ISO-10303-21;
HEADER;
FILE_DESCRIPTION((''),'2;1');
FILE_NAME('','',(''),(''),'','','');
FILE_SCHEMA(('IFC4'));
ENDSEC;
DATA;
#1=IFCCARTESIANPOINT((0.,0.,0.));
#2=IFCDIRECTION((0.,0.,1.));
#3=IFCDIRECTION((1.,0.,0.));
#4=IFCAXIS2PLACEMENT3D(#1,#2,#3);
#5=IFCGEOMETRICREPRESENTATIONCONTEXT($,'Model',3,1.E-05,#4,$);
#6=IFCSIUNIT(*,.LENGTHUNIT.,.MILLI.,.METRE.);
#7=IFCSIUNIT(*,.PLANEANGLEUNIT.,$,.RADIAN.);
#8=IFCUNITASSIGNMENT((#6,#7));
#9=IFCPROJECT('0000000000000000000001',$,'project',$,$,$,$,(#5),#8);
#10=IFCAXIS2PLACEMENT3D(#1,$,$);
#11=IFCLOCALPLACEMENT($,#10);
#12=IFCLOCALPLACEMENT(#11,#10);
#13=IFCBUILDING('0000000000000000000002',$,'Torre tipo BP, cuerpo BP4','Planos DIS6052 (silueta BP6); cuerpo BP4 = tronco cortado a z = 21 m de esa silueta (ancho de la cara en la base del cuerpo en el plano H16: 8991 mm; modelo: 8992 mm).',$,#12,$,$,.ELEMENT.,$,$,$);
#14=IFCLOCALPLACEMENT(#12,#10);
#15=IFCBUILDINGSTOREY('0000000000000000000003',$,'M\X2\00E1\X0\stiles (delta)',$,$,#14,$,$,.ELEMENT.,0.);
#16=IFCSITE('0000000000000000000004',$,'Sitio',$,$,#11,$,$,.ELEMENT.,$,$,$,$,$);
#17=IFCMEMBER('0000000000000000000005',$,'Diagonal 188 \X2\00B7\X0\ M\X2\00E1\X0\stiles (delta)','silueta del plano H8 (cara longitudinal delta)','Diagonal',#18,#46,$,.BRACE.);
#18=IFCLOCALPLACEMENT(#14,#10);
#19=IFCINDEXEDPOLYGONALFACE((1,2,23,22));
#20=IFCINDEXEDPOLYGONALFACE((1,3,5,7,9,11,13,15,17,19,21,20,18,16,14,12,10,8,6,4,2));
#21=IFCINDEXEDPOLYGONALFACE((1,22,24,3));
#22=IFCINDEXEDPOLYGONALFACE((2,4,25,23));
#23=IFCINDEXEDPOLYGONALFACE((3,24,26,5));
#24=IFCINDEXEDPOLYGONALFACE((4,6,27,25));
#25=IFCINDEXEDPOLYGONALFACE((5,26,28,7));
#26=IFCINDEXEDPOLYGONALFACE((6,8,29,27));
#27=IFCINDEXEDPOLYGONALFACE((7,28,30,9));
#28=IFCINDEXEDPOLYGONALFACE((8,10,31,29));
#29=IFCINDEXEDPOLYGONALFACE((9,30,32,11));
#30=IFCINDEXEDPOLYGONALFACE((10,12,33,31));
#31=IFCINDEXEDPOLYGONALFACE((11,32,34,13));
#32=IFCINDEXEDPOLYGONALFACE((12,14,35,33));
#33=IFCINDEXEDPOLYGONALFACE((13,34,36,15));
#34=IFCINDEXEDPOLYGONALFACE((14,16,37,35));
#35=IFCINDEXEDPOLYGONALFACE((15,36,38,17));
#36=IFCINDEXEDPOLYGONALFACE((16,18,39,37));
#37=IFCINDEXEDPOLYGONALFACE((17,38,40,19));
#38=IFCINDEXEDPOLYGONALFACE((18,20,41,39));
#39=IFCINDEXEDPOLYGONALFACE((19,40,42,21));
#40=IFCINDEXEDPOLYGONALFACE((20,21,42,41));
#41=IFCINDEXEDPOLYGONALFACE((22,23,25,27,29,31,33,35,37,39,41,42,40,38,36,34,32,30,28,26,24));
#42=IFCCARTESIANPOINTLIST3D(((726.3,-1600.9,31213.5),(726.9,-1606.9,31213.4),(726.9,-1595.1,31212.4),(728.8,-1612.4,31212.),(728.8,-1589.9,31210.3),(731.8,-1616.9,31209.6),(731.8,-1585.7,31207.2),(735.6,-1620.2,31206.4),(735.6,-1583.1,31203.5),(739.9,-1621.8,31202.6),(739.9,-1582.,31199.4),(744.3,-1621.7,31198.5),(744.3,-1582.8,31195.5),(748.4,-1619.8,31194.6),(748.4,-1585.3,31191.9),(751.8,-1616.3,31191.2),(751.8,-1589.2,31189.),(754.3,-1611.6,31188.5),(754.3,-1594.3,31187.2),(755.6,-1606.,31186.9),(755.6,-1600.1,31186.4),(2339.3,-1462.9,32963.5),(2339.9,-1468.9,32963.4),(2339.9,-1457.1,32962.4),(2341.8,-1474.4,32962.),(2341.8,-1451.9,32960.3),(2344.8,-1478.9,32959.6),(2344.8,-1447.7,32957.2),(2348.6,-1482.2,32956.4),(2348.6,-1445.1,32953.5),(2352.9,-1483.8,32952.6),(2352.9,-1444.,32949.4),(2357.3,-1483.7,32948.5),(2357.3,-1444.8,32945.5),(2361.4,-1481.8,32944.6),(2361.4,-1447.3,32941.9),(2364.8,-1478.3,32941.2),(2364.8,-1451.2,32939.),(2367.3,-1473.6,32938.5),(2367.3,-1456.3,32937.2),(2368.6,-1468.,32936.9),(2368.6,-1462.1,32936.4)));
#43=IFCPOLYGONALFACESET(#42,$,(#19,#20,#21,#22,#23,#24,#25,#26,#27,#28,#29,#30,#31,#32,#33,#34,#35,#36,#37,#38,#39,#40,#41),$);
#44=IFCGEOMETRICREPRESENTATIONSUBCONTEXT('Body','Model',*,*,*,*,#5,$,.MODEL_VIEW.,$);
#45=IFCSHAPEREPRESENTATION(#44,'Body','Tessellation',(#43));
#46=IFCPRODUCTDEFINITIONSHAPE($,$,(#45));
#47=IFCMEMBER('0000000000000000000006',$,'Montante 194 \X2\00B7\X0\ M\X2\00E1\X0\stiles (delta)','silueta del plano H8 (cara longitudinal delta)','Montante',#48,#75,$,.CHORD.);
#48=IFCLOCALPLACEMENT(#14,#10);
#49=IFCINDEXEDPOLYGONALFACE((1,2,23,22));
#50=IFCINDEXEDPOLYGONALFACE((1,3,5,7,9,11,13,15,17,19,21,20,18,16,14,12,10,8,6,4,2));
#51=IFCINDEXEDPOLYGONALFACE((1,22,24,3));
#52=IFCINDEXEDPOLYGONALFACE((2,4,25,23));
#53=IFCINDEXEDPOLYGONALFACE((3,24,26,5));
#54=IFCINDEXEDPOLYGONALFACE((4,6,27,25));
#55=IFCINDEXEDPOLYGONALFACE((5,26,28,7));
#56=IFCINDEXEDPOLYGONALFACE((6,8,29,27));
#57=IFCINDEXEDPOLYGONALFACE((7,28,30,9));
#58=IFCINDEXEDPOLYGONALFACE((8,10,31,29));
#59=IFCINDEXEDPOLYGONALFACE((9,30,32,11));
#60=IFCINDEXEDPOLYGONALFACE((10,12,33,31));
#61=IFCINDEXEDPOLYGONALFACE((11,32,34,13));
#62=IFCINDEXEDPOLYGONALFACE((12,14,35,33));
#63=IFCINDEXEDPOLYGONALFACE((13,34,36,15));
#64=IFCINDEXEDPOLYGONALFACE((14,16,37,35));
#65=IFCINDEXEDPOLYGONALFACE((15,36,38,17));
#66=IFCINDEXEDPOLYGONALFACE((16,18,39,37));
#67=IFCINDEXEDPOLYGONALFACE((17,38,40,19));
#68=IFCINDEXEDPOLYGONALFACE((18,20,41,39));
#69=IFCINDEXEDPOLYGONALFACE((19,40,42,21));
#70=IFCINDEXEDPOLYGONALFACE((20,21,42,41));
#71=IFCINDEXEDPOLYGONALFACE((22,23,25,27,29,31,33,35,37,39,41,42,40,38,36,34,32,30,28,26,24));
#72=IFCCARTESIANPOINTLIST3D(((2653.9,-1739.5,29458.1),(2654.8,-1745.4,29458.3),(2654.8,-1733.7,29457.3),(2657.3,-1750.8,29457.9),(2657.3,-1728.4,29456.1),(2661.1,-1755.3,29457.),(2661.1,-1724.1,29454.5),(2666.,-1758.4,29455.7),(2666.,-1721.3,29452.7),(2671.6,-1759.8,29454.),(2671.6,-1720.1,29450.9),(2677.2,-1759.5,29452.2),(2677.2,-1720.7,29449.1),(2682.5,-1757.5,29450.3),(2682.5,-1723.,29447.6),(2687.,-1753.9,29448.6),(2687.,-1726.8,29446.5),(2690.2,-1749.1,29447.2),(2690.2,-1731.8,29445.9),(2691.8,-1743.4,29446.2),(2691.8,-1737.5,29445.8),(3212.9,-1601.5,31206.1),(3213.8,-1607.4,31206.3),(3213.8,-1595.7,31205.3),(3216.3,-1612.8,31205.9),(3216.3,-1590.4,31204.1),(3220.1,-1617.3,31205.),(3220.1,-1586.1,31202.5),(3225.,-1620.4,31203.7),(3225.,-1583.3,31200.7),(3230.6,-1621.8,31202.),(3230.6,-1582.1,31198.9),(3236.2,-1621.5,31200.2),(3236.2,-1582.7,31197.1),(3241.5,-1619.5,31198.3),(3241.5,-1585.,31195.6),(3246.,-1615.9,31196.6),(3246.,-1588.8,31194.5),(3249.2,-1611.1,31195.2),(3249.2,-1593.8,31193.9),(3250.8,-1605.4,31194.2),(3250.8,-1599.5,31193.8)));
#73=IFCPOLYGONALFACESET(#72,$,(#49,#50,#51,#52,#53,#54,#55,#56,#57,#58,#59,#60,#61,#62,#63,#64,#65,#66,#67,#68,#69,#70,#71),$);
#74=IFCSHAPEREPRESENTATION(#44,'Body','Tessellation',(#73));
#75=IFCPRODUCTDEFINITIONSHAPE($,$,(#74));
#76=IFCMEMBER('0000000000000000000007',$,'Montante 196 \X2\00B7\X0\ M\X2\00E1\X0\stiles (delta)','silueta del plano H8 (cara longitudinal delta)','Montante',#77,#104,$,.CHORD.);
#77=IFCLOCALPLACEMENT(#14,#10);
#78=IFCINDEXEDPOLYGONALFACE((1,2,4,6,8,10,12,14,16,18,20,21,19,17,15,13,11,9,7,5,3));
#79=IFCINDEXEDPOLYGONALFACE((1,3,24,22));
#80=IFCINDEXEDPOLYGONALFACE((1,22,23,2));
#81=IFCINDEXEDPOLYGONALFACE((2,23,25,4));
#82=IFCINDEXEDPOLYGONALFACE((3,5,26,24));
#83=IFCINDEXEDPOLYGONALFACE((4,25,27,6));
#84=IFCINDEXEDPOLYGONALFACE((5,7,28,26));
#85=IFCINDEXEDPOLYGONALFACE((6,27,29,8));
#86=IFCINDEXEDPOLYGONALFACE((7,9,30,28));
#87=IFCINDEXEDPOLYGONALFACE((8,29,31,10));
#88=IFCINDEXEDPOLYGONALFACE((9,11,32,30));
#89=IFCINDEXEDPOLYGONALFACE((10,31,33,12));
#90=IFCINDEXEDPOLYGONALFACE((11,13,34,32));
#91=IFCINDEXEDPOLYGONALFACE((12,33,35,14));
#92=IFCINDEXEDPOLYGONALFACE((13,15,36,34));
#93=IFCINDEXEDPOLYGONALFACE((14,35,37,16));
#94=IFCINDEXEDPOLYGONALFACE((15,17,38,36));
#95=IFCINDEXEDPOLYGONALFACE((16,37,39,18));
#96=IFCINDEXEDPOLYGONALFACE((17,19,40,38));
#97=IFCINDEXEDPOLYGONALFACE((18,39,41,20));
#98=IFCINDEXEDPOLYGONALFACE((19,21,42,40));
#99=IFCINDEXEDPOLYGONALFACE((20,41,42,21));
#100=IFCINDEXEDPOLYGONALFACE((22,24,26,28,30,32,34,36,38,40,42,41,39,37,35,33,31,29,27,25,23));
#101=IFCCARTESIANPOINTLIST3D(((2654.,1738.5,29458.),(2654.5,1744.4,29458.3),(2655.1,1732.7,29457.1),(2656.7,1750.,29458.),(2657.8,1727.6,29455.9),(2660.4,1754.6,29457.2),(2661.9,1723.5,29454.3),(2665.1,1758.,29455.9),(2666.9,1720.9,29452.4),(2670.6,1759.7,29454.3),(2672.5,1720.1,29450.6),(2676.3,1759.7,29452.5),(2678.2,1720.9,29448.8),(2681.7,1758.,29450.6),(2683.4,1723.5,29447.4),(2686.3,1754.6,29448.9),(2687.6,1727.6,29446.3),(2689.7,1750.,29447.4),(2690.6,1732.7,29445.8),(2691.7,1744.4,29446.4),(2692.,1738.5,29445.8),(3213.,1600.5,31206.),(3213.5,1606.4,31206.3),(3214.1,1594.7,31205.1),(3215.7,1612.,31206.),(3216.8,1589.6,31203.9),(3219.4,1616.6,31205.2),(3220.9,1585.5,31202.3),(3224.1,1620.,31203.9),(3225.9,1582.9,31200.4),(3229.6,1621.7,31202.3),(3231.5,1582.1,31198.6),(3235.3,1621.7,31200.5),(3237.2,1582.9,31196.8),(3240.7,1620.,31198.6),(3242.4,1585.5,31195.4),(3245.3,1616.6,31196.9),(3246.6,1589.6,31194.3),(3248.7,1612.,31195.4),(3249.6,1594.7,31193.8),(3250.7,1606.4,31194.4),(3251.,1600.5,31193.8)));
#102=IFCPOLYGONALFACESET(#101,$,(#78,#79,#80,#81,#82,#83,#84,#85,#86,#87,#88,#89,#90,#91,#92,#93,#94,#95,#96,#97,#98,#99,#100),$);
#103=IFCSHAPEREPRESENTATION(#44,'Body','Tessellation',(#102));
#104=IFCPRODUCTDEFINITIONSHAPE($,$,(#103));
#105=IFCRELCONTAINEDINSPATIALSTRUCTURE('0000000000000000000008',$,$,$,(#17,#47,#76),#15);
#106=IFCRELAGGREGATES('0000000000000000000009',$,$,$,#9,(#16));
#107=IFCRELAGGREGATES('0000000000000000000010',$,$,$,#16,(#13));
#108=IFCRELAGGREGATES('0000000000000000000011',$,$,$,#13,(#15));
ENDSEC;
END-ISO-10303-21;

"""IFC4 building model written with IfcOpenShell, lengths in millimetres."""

from ifc_helpers import new_model, si_unit, frame, origin, origin_with_axes, place, context, subcontext, project, spatial, circle, extrude, element, save


model = new_model("IFC4")

# Units and contexts
model_context = context("Model", 3, precision=1e-05, world=origin_with_axes())
body_context = subcontext(model_context, "Body", "Model", "MODEL_VIEW")
ifc_project = project(units=[si_unit("LENGTHUNIT", "METRE", prefix="MILLI"), si_unit("PLANEANGLEUNIT", "RADIAN")], contexts=[model_context])

# Site, building, storey
site_placement = place(None, origin())
site = spatial("IfcSite", under=ifc_project, at=site_placement, Name="Sitio", CompositionType="ELEMENT")
building_placement = place(site_placement, origin())
building = spatial("IfcBuilding", under=site, at=building_placement, Name="Torre tipo BP, cuerpo BP4", Description="Planos DIS6052 (silueta BP6); cuerpo BP4 = tronco cortado a z = 21 m de esa silueta (ancho de la cara en la base del cuerpo en el plano H16: 8991 mm; modelo: 8992 mm).", CompositionType="ELEMENT")
storey_placement = place(building_placement, origin())
storey = spatial("IfcBuildingStorey", under=building, at=storey_placement, Name="Mástiles (delta)", CompositionType="ELEMENT", Elevation=0.0)

# Members
member_1_placement = place(storey_placement, frame((2354.0, -1464.0, 32950.0), z_axis=(-0.676602, -0.057887, -0.73407), x_axis=(-0.736348, 0.05319, 0.674509)))
element("IfcMember", 1, at=member_1_placement, inside=storey, Name="Diagonal 188 · Mástiles (delta)", Description="silueta del plano H8 (cara longitudinal delta)", ObjectType="Diagonal", PredefinedType="BRACE", context=body_context, shape_type="SweptSolid", body=[
    extrude(circle(Radius=20.0), None, (0.0, 0.0, 1.0), 2384.0),
])
for number, where, z_axis, x_axis, name in (
    (2, (3232.0, -1602.0, 31200.0), (-0.30374, -0.074984, -0.9498), (-0.952755, 0.023905, 0.302798), "Montante 194 · Mástiles (delta)"),
    (3, (3232.0, 1602.0, 31200.0), (-0.30374, 0.074984, -0.9498), (-0.02284, -0.997185, -0.071421), "Montante 196 · Mástiles (delta)"),
):
    element("IfcMember", number, at=place(storey_placement, frame(where, z_axis=z_axis, x_axis=x_axis)), inside=storey, Name=name, Description="silueta del plano H8 (cara longitudinal delta)", ObjectType="Montante", PredefinedType="CHORD", context=body_context, shape_type="SweptSolid", body=[
        extrude(circle(Radius=20.0), None, (0.0, 0.0, 1.0), 1840.4),
    ])

save(model, "model.ifc")
